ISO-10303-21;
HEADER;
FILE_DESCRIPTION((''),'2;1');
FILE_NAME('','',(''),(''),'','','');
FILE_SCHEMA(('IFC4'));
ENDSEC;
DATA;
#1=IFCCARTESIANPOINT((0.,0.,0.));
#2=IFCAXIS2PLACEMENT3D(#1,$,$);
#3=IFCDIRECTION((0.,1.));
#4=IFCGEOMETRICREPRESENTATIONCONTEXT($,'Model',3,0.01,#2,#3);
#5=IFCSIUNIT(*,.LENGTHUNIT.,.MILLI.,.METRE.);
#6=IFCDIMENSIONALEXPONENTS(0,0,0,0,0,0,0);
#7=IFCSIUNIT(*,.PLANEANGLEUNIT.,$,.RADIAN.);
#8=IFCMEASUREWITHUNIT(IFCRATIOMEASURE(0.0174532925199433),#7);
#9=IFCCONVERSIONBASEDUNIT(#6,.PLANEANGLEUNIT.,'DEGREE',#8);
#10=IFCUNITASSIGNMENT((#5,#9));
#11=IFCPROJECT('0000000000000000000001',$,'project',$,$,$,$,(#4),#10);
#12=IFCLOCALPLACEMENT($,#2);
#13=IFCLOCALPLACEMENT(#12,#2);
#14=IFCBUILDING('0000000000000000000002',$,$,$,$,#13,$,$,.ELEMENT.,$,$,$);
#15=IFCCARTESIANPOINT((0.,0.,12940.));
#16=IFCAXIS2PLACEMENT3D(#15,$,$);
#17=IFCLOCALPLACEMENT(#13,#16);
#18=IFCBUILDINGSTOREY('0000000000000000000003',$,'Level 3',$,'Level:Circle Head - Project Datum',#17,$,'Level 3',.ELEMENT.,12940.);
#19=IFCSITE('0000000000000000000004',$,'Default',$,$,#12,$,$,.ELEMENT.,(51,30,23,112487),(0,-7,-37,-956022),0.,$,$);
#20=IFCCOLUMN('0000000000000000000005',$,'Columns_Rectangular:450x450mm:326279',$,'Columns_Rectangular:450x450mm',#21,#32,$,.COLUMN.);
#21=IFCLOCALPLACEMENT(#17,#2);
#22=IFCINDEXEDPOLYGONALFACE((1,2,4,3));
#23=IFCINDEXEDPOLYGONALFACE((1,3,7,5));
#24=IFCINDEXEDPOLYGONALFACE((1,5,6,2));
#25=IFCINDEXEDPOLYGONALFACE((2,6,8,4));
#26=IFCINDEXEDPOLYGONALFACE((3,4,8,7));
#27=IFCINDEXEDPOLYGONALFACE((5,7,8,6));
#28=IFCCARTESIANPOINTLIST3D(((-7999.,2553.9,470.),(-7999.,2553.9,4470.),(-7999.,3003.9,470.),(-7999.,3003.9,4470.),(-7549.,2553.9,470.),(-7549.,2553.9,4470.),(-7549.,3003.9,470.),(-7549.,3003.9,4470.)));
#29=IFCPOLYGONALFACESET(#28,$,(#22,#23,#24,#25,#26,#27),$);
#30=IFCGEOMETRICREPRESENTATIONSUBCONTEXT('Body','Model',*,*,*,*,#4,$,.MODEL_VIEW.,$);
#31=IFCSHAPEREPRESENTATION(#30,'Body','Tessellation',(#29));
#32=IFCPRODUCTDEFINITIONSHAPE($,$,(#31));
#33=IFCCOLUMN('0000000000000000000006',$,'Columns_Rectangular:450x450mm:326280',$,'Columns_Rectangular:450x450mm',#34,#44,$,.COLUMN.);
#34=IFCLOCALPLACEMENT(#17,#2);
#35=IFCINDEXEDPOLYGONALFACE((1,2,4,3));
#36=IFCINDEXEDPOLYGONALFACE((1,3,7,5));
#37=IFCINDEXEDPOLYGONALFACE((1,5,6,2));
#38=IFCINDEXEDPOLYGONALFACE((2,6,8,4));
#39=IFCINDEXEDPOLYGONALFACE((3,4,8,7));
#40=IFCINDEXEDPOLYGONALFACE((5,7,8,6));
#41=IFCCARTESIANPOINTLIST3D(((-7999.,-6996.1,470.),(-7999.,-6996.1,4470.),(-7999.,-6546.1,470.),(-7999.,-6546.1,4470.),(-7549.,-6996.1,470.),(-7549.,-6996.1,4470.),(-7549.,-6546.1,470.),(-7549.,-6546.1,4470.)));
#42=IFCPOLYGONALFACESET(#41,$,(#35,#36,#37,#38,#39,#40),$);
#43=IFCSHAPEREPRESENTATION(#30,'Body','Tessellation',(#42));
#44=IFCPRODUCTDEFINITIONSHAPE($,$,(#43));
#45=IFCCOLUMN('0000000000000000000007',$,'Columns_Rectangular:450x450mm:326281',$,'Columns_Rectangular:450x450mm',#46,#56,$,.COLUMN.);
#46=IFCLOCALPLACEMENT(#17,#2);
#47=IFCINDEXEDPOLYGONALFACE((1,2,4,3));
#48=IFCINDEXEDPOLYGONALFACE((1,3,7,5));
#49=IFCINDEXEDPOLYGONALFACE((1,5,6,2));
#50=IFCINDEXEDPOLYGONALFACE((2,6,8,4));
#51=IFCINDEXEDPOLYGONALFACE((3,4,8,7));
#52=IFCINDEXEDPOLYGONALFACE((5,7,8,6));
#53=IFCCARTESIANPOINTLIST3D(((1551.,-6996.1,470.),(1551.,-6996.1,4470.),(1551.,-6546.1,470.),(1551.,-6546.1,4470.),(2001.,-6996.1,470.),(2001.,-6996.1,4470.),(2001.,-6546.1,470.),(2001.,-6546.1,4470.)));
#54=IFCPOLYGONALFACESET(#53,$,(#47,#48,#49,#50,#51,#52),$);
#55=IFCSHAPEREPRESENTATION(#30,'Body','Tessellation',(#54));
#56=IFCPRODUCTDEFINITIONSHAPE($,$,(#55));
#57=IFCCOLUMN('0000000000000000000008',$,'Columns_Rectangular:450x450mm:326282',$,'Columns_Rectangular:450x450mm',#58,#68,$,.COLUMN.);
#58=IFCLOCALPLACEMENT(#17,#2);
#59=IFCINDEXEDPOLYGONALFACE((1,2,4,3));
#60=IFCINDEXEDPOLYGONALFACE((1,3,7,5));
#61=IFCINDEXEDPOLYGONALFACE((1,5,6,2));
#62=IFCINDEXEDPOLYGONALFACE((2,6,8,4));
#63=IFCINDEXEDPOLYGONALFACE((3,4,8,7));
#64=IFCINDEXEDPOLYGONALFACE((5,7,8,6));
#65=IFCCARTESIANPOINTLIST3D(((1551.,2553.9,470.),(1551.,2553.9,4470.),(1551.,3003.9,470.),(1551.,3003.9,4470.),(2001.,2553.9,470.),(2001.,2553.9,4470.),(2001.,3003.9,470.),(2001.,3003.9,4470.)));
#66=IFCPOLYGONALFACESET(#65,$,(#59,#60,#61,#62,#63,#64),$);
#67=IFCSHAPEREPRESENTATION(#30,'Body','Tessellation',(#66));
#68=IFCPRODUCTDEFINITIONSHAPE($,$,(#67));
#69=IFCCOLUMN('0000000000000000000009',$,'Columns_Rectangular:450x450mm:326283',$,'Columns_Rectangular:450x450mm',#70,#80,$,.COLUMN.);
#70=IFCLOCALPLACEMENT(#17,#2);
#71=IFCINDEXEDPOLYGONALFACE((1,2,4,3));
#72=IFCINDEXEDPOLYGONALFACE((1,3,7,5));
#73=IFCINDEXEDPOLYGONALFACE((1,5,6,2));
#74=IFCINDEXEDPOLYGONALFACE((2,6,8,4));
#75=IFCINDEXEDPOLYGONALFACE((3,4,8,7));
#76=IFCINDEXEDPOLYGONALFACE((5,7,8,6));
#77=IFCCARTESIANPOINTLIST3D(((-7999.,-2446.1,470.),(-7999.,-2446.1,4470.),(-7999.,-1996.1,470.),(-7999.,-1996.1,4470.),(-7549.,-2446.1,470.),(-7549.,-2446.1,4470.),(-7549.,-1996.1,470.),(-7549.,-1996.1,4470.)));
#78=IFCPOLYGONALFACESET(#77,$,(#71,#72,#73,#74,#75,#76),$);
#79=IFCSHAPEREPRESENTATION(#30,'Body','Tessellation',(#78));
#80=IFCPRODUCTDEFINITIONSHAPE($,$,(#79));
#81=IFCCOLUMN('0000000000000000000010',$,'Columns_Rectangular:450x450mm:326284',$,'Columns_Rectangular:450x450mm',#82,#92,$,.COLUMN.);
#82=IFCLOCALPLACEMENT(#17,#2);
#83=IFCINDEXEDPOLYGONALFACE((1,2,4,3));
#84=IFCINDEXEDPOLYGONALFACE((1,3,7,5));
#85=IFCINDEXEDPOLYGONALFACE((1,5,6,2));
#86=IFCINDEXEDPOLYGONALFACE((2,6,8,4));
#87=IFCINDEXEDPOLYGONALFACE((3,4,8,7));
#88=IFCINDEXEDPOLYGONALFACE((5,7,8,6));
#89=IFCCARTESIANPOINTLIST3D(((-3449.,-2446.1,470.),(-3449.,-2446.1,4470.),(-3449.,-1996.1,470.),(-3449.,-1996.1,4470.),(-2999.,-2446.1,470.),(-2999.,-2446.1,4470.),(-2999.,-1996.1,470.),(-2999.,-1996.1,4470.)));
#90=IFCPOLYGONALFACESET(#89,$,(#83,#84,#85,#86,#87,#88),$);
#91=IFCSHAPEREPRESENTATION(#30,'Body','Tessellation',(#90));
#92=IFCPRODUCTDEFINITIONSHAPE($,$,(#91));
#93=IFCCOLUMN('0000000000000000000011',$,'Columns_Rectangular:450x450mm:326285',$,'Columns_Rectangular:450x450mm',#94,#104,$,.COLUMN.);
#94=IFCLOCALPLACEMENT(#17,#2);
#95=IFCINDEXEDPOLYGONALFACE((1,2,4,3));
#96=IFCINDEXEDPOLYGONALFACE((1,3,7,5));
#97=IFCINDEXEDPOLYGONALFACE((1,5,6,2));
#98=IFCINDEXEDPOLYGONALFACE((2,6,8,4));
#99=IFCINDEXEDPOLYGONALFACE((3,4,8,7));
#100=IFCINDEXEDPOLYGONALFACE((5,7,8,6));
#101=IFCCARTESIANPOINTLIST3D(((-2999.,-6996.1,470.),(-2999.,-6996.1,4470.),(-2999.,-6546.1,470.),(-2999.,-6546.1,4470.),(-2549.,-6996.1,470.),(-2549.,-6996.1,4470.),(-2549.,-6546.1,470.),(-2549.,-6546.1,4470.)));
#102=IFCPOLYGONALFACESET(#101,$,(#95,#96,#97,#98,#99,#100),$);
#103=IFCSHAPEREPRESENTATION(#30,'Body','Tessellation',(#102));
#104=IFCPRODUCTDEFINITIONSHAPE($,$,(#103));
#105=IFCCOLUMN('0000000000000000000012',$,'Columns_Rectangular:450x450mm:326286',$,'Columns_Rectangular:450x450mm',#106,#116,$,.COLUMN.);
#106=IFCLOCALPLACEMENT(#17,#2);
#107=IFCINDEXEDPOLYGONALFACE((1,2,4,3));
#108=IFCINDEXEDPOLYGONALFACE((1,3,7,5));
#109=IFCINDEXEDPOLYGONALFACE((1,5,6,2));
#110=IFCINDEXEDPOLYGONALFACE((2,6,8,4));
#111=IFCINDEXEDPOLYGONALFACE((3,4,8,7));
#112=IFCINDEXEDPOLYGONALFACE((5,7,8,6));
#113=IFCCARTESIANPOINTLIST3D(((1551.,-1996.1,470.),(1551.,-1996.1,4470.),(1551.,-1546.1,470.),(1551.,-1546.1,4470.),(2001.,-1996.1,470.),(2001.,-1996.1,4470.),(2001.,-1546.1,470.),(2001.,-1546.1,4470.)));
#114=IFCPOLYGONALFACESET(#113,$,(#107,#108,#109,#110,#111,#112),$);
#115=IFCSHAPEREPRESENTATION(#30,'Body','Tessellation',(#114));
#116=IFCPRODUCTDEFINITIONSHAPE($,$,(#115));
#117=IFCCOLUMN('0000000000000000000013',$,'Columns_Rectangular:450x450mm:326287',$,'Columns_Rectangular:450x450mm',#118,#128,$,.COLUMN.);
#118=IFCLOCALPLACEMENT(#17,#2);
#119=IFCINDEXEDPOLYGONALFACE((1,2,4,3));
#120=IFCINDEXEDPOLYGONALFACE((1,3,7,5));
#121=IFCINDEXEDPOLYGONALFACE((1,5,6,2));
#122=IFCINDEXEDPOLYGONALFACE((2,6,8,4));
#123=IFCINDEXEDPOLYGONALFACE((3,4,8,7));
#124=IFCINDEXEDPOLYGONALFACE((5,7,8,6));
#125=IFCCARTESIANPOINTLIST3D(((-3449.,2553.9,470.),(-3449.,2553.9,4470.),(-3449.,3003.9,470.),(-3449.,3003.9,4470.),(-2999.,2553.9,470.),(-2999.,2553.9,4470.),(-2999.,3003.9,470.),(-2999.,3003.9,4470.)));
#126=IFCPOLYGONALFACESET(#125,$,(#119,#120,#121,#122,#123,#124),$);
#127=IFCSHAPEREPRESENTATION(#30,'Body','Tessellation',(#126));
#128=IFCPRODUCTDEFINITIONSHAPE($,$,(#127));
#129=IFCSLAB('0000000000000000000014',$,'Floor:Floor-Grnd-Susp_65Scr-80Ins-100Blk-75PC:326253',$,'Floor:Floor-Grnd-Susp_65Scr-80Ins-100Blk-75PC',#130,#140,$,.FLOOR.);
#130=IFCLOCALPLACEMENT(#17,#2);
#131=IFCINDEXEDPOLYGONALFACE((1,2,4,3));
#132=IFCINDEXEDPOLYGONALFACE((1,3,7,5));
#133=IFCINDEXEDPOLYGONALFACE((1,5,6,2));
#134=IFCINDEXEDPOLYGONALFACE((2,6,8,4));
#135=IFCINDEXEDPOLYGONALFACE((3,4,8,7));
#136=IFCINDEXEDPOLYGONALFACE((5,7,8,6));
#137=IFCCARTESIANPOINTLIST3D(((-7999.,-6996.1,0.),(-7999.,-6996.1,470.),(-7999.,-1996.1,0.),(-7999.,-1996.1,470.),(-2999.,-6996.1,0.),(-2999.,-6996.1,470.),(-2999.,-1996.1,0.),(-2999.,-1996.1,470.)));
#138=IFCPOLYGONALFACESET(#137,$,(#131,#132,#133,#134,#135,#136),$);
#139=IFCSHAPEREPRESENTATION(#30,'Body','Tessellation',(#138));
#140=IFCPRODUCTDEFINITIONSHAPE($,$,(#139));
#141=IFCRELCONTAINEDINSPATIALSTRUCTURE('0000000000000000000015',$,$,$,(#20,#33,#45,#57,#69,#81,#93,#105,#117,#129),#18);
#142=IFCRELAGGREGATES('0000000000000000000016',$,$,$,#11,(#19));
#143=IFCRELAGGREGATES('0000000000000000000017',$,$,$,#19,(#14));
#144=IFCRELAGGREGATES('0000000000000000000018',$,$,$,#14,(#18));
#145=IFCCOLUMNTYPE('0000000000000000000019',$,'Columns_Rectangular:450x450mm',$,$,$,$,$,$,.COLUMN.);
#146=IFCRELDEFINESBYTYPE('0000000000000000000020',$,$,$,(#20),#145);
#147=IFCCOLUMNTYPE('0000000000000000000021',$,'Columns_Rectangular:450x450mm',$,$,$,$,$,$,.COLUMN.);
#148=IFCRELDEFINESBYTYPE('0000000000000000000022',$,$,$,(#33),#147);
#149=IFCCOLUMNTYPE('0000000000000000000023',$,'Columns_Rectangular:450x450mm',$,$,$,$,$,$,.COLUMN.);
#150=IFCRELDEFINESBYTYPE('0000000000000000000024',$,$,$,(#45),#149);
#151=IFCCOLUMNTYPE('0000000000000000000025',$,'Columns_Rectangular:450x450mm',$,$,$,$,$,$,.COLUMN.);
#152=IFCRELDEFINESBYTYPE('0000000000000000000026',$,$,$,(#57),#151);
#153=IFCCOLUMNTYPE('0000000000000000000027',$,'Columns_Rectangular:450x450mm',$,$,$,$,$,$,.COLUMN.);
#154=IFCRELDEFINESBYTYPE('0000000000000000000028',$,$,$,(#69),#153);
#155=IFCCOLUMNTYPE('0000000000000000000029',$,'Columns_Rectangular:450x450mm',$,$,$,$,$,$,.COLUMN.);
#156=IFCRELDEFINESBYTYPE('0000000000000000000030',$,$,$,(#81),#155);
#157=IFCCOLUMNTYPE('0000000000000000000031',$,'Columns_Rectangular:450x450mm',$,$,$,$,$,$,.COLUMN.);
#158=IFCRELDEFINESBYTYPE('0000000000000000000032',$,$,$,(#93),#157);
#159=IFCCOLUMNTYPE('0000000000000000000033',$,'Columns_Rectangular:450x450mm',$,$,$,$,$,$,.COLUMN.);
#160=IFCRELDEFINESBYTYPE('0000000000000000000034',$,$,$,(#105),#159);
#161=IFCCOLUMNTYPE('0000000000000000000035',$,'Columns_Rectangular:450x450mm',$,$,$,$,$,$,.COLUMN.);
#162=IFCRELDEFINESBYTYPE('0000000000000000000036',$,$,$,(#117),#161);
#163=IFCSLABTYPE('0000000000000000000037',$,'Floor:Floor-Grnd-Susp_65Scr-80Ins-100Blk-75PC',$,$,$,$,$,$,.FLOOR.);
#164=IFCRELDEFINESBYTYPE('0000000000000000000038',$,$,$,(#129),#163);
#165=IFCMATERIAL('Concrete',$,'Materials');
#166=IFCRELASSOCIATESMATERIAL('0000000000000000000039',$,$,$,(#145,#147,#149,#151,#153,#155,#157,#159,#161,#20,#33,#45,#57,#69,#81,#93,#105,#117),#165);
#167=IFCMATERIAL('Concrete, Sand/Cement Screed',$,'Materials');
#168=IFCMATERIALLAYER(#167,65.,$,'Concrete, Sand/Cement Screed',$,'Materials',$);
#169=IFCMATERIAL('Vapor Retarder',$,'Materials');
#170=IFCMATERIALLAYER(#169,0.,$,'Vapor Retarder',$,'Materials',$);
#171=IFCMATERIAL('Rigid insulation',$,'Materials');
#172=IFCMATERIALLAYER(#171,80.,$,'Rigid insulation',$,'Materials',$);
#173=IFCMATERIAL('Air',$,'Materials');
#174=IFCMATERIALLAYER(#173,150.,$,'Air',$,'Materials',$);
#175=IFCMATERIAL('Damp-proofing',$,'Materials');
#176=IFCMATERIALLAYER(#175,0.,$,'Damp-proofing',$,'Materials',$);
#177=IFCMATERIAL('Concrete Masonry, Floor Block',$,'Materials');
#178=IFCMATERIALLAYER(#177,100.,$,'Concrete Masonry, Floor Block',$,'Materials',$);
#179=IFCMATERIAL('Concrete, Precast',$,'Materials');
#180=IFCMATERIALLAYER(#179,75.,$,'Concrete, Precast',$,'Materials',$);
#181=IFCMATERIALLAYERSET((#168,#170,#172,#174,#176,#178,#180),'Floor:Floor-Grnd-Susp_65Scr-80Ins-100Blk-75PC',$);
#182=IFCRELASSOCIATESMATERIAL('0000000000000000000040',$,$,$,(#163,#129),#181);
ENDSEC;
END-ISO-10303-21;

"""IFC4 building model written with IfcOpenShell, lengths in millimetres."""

from ifc_helpers import new_model, entity, si_unit, converted_unit, direction, frame, frame_2d, origin, origin_2d_with_axis, place, context, subcontext, project, spatial, polyline, segment, composite_curve, rectangle, outline, extrude, source, transform, mapped, material, layer, layer_set, layer_usage, material_profile, profile_set, profile_usage, type_object, type_shapes, element, save


model = new_model("IFC4")

# Units and contexts
model_context = context("Model", 3, precision=0.01, world=origin(), true_north=direction((0.0, 1.0)))
body_context = subcontext(model_context, "Body", "Model", "MODEL_VIEW")
ifc_project = project(units=[si_unit("LENGTHUNIT", "METRE", prefix="MILLI"), converted_unit("PLANEANGLEUNIT", "DEGREE", entity("IfcRatioMeasure", 0.0174532925199433), si_unit("PLANEANGLEUNIT", "RADIAN"), dimensions=[0, 0, 0, 0, 0, 0, 0])], contexts=[model_context])

# Site, building, storey
site_placement = place(None, origin())
site = spatial("IfcSite", under=ifc_project, at=site_placement, Name="Default", CompositionType="ELEMENT", RefLatitude=(51, 30, 23, 112487), RefLongitude=(0, -7, -37, -956022), RefElevation=0.0)
building_placement = place(site_placement, origin())
building = spatial("IfcBuilding", under=site, at=building_placement, CompositionType="ELEMENT")
storey_placement = place(building_placement, frame((0.0, 0.0, 12940.0)))
storey = spatial("IfcBuildingStorey", under=building, at=storey_placement, Name="Level 3", ObjectType="Level:Circle Head - Project Datum", LongName="Level 3", CompositionType="ELEMENT", Elevation=12940.0)

# Columns
ifc_material_1 = material(Name="Concrete", Category="Materials")
ifc_material_profile = material_profile(ifc_material_1, outline(composite_curve([segment(polyline([(225.0, 225.0, 0.0), (225.0, -225.0, 0.0)]), True, "CONTINUOUS"), segment(polyline([(225.0, -225.0, 0.0), (-225.0, -225.0, 0.0)]), True, "CONTINUOUS"), segment(polyline([(-225.0, -225.0, 0.0), (-225.0, 225.0, 0.0)]), True, "CONTINUOUS"), segment(polyline([(-225.0, 225.0, 0.0), (225.0, 225.0, 0.0)]), True, "CONTINUOUS")], self_intersect=False), kind="CURVE"), Name="450x450mm")
ifc_profile_set = profile_set([ifc_material_profile], Name="450x450mm")
ifc_profile_usage_1 = profile_usage(ifc_profile_set)
column_type_1 = type_object("IfcColumnType", Name="Columns_Rectangular:450x450mm", PredefinedType="COLUMN", material=ifc_profile_set)
shared_shape_1 = source(origin(), body_context, "Body", "SweptSolid", [
    extrude(rectangle(XDim=450.0, YDim=450.0, at=frame_2d((0.0, 0.0), x_axis=(1.0, 0.0))), frame((-7774.0, 2778.9, 13410.0), z_axis=(0.0, 0.0, 1.0), x_axis=(0.0, -1.0, 0.0)), (0.0, 0.0, 1.0), 4000.0),
])
type_shapes(column_type_1, [shared_shape_1])
column_1_placement = place(storey_placement, frame((0.0, 0.0, -12940.0)))
element("IfcColumn", 1, at=column_1_placement, inside=storey, type_object=column_type_1, material=ifc_profile_usage_1, Name="Columns_Rectangular:450x450mm:326279", ObjectType="Columns_Rectangular:450x450mm", PredefinedType="COLUMN", context=body_context, shape_type="MappedRepresentation", body=[
    mapped(shared_shape_1, transform((0.0, 0.0, 0.0), scale=1.0)),
])
ifc_profile_usage_2 = profile_usage(ifc_profile_set)
column_type_2 = type_object("IfcColumnType", Name="Columns_Rectangular:450x450mm", PredefinedType="COLUMN", material=ifc_profile_set)
shared_shape_2 = source(origin(), body_context, "Body", "SweptSolid", [
    extrude(rectangle(XDim=450.0, YDim=450.0, at=frame_2d((0.0, 0.0), x_axis=(1.0, 0.0))), frame((-7774.0, -6771.1, 13410.0), z_axis=(0.0, 0.0, 1.0), x_axis=(0.0, -1.0, 0.0)), (0.0, 0.0, 1.0), 4000.0),
])
type_shapes(column_type_2, [shared_shape_2])
column_2_placement = place(storey_placement, frame((0.0, 0.0, -12940.0)))
element("IfcColumn", 2, at=column_2_placement, inside=storey, type_object=column_type_2, material=ifc_profile_usage_2, Name="Columns_Rectangular:450x450mm:326280", ObjectType="Columns_Rectangular:450x450mm", PredefinedType="COLUMN", context=body_context, shape_type="MappedRepresentation", body=[
    mapped(shared_shape_2, transform((0.0, 0.0, 0.0), scale=1.0)),
])
ifc_profile_usage_3 = profile_usage(ifc_profile_set)
column_type_3 = type_object("IfcColumnType", Name="Columns_Rectangular:450x450mm", PredefinedType="COLUMN", material=ifc_profile_set)
shared_shape_3 = source(origin(), body_context, "Body", "SweptSolid", [
    extrude(rectangle(XDim=450.0, YDim=450.0, at=frame_2d((0.0, 0.0), x_axis=(1.0, 0.0))), frame((1776.0, -6771.1, 13410.0), z_axis=(0.0, 0.0, 1.0), x_axis=(0.0, -1.0, 0.0)), (0.0, 0.0, 1.0), 4000.0),
])
type_shapes(column_type_3, [shared_shape_3])
column_3_placement = place(storey_placement, frame((0.0, 0.0, -12940.0)))
element("IfcColumn", 3, at=column_3_placement, inside=storey, type_object=column_type_3, material=ifc_profile_usage_3, Name="Columns_Rectangular:450x450mm:326281", ObjectType="Columns_Rectangular:450x450mm", PredefinedType="COLUMN", context=body_context, shape_type="MappedRepresentation", body=[
    mapped(shared_shape_3, transform((0.0, 0.0, 0.0), scale=1.0)),
])
ifc_profile_usage_4 = profile_usage(ifc_profile_set)
column_type_4 = type_object("IfcColumnType", Name="Columns_Rectangular:450x450mm", PredefinedType="COLUMN", material=ifc_profile_set)
shared_shape_4 = source(origin(), body_context, "Body", "SweptSolid", [
    extrude(rectangle(XDim=450.0, YDim=450.0, at=frame_2d((0.0, 0.0), x_axis=(1.0, 0.0))), frame((1776.0, 2778.9, 13410.0), z_axis=(0.0, 0.0, 1.0), x_axis=(0.0, -1.0, 0.0)), (0.0, 0.0, 1.0), 4000.0),
])
type_shapes(column_type_4, [shared_shape_4])
column_4_placement = place(storey_placement, frame((0.0, 0.0, -12940.0)))
element("IfcColumn", 4, at=column_4_placement, inside=storey, type_object=column_type_4, material=ifc_profile_usage_4, Name="Columns_Rectangular:450x450mm:326282", ObjectType="Columns_Rectangular:450x450mm", PredefinedType="COLUMN", context=body_context, shape_type="MappedRepresentation", body=[
    mapped(shared_shape_4, transform((0.0, 0.0, 0.0), scale=1.0)),
])
ifc_profile_usage_5 = profile_usage(ifc_profile_set)
column_type_5 = type_object("IfcColumnType", Name="Columns_Rectangular:450x450mm", PredefinedType="COLUMN", material=ifc_profile_set)
shared_shape_5 = source(origin(), body_context, "Body", "SweptSolid", [
    extrude(rectangle(XDim=450.0, YDim=450.0, at=frame_2d((0.0, 0.0), x_axis=(1.0, 0.0))), frame((-7774.0, -2221.1, 13410.0), z_axis=(0.0, 0.0, 1.0), x_axis=(0.0, -1.0, 0.0)), (0.0, 0.0, 1.0), 4000.0),
])
type_shapes(column_type_5, [shared_shape_5])
column_5_placement = place(storey_placement, frame((0.0, 0.0, -12940.0)))
element("IfcColumn", 5, at=column_5_placement, inside=storey, type_object=column_type_5, material=ifc_profile_usage_5, Name="Columns_Rectangular:450x450mm:326283", ObjectType="Columns_Rectangular:450x450mm", PredefinedType="COLUMN", context=body_context, shape_type="MappedRepresentation", body=[
    mapped(shared_shape_5, transform((0.0, 0.0, 0.0), scale=1.0)),
])
ifc_profile_usage_6 = profile_usage(ifc_profile_set)
column_type_6 = type_object("IfcColumnType", Name="Columns_Rectangular:450x450mm", PredefinedType="COLUMN", material=ifc_profile_set)
shared_shape_6 = source(origin(), body_context, "Body", "SweptSolid", [
    extrude(rectangle(XDim=450.0, YDim=450.0, at=origin_2d_with_axis()), frame((0.0, 0.0, 13410.0), z_axis=(0.0, 0.0, 1.0), x_axis=(0.0, -1.0, 0.0)), (0.0, 0.0, 1.0), 4000.0),
])
type_shapes(column_type_6, [shared_shape_6])
column_6_placement = place(storey_placement, frame((-3224.0, -2221.1, -12940.0)))
element("IfcColumn", 6, at=column_6_placement, inside=storey, type_object=column_type_6, material=ifc_profile_usage_6, Name="Columns_Rectangular:450x450mm:326284", ObjectType="Columns_Rectangular:450x450mm", PredefinedType="COLUMN", context=body_context, shape_type="MappedRepresentation", body=[
    mapped(shared_shape_6, transform((0.0, 0.0, 0.0), scale=1.0)),
])
ifc_profile_usage_7 = profile_usage(ifc_profile_set)
column_type_7 = type_object("IfcColumnType", Name="Columns_Rectangular:450x450mm", PredefinedType="COLUMN", material=ifc_profile_set)
shared_shape_7 = source(origin(), body_context, "Body", "SweptSolid", [
    extrude(rectangle(XDim=450.0, YDim=450.0, at=frame_2d((0.0, 0.0), x_axis=(1.0, 0.0))), frame((-2774.0, -6771.1, 13410.0), z_axis=(0.0, 0.0, 1.0), x_axis=(0.0, -1.0, 0.0)), (0.0, 0.0, 1.0), 4000.0),
])
type_shapes(column_type_7, [shared_shape_7])
column_7_placement = place(storey_placement, frame((0.0, 0.0, -12940.0)))
element("IfcColumn", 7, at=column_7_placement, inside=storey, type_object=column_type_7, material=ifc_profile_usage_7, Name="Columns_Rectangular:450x450mm:326285", ObjectType="Columns_Rectangular:450x450mm", PredefinedType="COLUMN", context=body_context, shape_type="MappedRepresentation", body=[
    mapped(shared_shape_7, transform((0.0, 0.0, 0.0), scale=1.0)),
])
ifc_profile_usage_8 = profile_usage(ifc_profile_set)
column_type_8 = type_object("IfcColumnType", Name="Columns_Rectangular:450x450mm", PredefinedType="COLUMN", material=ifc_profile_set)
shared_shape_8 = source(origin(), body_context, "Body", "SweptSolid", [
    extrude(rectangle(XDim=450.0, YDim=450.0, at=frame_2d((0.0, 0.0), x_axis=(1.0, 0.0))), frame((1776.0, -1771.1, 13410.0), z_axis=(0.0, 0.0, 1.0), x_axis=(0.0, -1.0, 0.0)), (0.0, 0.0, 1.0), 4000.0),
])
type_shapes(column_type_8, [shared_shape_8])
column_8_placement = place(storey_placement, frame((0.0, 0.0, -12940.0)))
element("IfcColumn", 8, at=column_8_placement, inside=storey, type_object=column_type_8, material=ifc_profile_usage_8, Name="Columns_Rectangular:450x450mm:326286", ObjectType="Columns_Rectangular:450x450mm", PredefinedType="COLUMN", context=body_context, shape_type="MappedRepresentation", body=[
    mapped(shared_shape_8, transform((0.0, 0.0, 0.0), scale=1.0)),
])
ifc_profile_usage_9 = profile_usage(ifc_profile_set)
column_type_9 = type_object("IfcColumnType", Name="Columns_Rectangular:450x450mm", PredefinedType="COLUMN", material=ifc_profile_set)
shared_shape_9 = source(origin(), body_context, "Body", "SweptSolid", [
    extrude(rectangle(XDim=450.0, YDim=450.0, at=frame_2d((0.0, 0.0), x_axis=(1.0, 0.0))), frame((-3224.0, 2778.9, 13410.0), z_axis=(0.0, 0.0, 1.0), x_axis=(0.0, -1.0, 0.0)), (0.0, 0.0, 1.0), 4000.0),
])
type_shapes(column_type_9, [shared_shape_9])
column_9_placement = place(storey_placement, frame((0.0, 0.0, -12940.0)))
element("IfcColumn", 9, at=column_9_placement, inside=storey, type_object=column_type_9, material=ifc_profile_usage_9, Name="Columns_Rectangular:450x450mm:326287", ObjectType="Columns_Rectangular:450x450mm", PredefinedType="COLUMN", context=body_context, shape_type="MappedRepresentation", body=[
    mapped(shared_shape_9, transform((0.0, 0.0, 0.0), scale=1.0)),
])

# Slab
ifc_material_2 = material(Name="Concrete, Sand/Cement Screed", Category="Materials")
ifc_layer_1 = layer(ifc_material_2, 65.0, Name="Concrete, Sand/Cement Screed", Category="Materials")
ifc_material_3 = material(Name="Vapor Retarder", Category="Materials")
ifc_layer_2 = layer(ifc_material_3, 0.0, Name="Vapor Retarder", Category="Materials")
ifc_material_4 = material(Name="Rigid insulation", Category="Materials")
ifc_layer_3 = layer(ifc_material_4, 80.0, Name="Rigid insulation", Category="Materials")
ifc_material_5 = material(Name="Air", Category="Materials")
ifc_layer_4 = layer(ifc_material_5, 150.0, Name="Air", Category="Materials")
ifc_material_6 = material(Name="Damp-proofing", Category="Materials")
ifc_layer_5 = layer(ifc_material_6, 0.0, Name="Damp-proofing", Category="Materials")
ifc_material_7 = material(Name="Concrete Masonry, Floor Block", Category="Materials")
ifc_layer_6 = layer(ifc_material_7, 100.0, Name="Concrete Masonry, Floor Block", Category="Materials")
ifc_material_8 = material(Name="Concrete, Precast", Category="Materials")
ifc_layer_7 = layer(ifc_material_8, 75.0, Name="Concrete, Precast", Category="Materials")
ifc_layer_set_1 = layer_set([ifc_layer_1, ifc_layer_2, ifc_layer_3, ifc_layer_4, ifc_layer_5, ifc_layer_6, ifc_layer_7], Name="Floor:Floor-Grnd-Susp_65Scr-80Ins-100Blk-75PC")
ifc_layer_usage_1 = layer_usage(ifc_layer_set_1, "AXIS3", "POSITIVE", 0.0)
slab_type_1 = type_object("IfcSlabType", Name="Floor:Floor-Grnd-Susp_65Scr-80Ins-100Blk-75PC", PredefinedType="FLOOR", material=ifc_layer_set_1)
slab_1_placement = place(storey_placement, origin())
element("IfcSlab", 10, at=slab_1_placement, inside=storey, type_object=slab_type_1, material=ifc_layer_usage_1, Name="Floor:Floor-Grnd-Susp_65Scr-80Ins-100Blk-75PC:326253", ObjectType="Floor:Floor-Grnd-Susp_65Scr-80Ins-100Blk-75PC", PredefinedType="FLOOR", context=body_context, shape_type="SweptSolid", body=[
    extrude(rectangle(XDim=5000.0, YDim=5000.0, at=frame_2d((0.0, 0.0), x_axis=(1.0, 0.0))), frame((-5499.0, -4496.1, 470.0), z_axis=(0.0, 0.0, -1.0), x_axis=(0.0, 1.0, 0.0)), (0.0, 0.0, 1.0), 470.0),
])

save(model, "model.ifc")
